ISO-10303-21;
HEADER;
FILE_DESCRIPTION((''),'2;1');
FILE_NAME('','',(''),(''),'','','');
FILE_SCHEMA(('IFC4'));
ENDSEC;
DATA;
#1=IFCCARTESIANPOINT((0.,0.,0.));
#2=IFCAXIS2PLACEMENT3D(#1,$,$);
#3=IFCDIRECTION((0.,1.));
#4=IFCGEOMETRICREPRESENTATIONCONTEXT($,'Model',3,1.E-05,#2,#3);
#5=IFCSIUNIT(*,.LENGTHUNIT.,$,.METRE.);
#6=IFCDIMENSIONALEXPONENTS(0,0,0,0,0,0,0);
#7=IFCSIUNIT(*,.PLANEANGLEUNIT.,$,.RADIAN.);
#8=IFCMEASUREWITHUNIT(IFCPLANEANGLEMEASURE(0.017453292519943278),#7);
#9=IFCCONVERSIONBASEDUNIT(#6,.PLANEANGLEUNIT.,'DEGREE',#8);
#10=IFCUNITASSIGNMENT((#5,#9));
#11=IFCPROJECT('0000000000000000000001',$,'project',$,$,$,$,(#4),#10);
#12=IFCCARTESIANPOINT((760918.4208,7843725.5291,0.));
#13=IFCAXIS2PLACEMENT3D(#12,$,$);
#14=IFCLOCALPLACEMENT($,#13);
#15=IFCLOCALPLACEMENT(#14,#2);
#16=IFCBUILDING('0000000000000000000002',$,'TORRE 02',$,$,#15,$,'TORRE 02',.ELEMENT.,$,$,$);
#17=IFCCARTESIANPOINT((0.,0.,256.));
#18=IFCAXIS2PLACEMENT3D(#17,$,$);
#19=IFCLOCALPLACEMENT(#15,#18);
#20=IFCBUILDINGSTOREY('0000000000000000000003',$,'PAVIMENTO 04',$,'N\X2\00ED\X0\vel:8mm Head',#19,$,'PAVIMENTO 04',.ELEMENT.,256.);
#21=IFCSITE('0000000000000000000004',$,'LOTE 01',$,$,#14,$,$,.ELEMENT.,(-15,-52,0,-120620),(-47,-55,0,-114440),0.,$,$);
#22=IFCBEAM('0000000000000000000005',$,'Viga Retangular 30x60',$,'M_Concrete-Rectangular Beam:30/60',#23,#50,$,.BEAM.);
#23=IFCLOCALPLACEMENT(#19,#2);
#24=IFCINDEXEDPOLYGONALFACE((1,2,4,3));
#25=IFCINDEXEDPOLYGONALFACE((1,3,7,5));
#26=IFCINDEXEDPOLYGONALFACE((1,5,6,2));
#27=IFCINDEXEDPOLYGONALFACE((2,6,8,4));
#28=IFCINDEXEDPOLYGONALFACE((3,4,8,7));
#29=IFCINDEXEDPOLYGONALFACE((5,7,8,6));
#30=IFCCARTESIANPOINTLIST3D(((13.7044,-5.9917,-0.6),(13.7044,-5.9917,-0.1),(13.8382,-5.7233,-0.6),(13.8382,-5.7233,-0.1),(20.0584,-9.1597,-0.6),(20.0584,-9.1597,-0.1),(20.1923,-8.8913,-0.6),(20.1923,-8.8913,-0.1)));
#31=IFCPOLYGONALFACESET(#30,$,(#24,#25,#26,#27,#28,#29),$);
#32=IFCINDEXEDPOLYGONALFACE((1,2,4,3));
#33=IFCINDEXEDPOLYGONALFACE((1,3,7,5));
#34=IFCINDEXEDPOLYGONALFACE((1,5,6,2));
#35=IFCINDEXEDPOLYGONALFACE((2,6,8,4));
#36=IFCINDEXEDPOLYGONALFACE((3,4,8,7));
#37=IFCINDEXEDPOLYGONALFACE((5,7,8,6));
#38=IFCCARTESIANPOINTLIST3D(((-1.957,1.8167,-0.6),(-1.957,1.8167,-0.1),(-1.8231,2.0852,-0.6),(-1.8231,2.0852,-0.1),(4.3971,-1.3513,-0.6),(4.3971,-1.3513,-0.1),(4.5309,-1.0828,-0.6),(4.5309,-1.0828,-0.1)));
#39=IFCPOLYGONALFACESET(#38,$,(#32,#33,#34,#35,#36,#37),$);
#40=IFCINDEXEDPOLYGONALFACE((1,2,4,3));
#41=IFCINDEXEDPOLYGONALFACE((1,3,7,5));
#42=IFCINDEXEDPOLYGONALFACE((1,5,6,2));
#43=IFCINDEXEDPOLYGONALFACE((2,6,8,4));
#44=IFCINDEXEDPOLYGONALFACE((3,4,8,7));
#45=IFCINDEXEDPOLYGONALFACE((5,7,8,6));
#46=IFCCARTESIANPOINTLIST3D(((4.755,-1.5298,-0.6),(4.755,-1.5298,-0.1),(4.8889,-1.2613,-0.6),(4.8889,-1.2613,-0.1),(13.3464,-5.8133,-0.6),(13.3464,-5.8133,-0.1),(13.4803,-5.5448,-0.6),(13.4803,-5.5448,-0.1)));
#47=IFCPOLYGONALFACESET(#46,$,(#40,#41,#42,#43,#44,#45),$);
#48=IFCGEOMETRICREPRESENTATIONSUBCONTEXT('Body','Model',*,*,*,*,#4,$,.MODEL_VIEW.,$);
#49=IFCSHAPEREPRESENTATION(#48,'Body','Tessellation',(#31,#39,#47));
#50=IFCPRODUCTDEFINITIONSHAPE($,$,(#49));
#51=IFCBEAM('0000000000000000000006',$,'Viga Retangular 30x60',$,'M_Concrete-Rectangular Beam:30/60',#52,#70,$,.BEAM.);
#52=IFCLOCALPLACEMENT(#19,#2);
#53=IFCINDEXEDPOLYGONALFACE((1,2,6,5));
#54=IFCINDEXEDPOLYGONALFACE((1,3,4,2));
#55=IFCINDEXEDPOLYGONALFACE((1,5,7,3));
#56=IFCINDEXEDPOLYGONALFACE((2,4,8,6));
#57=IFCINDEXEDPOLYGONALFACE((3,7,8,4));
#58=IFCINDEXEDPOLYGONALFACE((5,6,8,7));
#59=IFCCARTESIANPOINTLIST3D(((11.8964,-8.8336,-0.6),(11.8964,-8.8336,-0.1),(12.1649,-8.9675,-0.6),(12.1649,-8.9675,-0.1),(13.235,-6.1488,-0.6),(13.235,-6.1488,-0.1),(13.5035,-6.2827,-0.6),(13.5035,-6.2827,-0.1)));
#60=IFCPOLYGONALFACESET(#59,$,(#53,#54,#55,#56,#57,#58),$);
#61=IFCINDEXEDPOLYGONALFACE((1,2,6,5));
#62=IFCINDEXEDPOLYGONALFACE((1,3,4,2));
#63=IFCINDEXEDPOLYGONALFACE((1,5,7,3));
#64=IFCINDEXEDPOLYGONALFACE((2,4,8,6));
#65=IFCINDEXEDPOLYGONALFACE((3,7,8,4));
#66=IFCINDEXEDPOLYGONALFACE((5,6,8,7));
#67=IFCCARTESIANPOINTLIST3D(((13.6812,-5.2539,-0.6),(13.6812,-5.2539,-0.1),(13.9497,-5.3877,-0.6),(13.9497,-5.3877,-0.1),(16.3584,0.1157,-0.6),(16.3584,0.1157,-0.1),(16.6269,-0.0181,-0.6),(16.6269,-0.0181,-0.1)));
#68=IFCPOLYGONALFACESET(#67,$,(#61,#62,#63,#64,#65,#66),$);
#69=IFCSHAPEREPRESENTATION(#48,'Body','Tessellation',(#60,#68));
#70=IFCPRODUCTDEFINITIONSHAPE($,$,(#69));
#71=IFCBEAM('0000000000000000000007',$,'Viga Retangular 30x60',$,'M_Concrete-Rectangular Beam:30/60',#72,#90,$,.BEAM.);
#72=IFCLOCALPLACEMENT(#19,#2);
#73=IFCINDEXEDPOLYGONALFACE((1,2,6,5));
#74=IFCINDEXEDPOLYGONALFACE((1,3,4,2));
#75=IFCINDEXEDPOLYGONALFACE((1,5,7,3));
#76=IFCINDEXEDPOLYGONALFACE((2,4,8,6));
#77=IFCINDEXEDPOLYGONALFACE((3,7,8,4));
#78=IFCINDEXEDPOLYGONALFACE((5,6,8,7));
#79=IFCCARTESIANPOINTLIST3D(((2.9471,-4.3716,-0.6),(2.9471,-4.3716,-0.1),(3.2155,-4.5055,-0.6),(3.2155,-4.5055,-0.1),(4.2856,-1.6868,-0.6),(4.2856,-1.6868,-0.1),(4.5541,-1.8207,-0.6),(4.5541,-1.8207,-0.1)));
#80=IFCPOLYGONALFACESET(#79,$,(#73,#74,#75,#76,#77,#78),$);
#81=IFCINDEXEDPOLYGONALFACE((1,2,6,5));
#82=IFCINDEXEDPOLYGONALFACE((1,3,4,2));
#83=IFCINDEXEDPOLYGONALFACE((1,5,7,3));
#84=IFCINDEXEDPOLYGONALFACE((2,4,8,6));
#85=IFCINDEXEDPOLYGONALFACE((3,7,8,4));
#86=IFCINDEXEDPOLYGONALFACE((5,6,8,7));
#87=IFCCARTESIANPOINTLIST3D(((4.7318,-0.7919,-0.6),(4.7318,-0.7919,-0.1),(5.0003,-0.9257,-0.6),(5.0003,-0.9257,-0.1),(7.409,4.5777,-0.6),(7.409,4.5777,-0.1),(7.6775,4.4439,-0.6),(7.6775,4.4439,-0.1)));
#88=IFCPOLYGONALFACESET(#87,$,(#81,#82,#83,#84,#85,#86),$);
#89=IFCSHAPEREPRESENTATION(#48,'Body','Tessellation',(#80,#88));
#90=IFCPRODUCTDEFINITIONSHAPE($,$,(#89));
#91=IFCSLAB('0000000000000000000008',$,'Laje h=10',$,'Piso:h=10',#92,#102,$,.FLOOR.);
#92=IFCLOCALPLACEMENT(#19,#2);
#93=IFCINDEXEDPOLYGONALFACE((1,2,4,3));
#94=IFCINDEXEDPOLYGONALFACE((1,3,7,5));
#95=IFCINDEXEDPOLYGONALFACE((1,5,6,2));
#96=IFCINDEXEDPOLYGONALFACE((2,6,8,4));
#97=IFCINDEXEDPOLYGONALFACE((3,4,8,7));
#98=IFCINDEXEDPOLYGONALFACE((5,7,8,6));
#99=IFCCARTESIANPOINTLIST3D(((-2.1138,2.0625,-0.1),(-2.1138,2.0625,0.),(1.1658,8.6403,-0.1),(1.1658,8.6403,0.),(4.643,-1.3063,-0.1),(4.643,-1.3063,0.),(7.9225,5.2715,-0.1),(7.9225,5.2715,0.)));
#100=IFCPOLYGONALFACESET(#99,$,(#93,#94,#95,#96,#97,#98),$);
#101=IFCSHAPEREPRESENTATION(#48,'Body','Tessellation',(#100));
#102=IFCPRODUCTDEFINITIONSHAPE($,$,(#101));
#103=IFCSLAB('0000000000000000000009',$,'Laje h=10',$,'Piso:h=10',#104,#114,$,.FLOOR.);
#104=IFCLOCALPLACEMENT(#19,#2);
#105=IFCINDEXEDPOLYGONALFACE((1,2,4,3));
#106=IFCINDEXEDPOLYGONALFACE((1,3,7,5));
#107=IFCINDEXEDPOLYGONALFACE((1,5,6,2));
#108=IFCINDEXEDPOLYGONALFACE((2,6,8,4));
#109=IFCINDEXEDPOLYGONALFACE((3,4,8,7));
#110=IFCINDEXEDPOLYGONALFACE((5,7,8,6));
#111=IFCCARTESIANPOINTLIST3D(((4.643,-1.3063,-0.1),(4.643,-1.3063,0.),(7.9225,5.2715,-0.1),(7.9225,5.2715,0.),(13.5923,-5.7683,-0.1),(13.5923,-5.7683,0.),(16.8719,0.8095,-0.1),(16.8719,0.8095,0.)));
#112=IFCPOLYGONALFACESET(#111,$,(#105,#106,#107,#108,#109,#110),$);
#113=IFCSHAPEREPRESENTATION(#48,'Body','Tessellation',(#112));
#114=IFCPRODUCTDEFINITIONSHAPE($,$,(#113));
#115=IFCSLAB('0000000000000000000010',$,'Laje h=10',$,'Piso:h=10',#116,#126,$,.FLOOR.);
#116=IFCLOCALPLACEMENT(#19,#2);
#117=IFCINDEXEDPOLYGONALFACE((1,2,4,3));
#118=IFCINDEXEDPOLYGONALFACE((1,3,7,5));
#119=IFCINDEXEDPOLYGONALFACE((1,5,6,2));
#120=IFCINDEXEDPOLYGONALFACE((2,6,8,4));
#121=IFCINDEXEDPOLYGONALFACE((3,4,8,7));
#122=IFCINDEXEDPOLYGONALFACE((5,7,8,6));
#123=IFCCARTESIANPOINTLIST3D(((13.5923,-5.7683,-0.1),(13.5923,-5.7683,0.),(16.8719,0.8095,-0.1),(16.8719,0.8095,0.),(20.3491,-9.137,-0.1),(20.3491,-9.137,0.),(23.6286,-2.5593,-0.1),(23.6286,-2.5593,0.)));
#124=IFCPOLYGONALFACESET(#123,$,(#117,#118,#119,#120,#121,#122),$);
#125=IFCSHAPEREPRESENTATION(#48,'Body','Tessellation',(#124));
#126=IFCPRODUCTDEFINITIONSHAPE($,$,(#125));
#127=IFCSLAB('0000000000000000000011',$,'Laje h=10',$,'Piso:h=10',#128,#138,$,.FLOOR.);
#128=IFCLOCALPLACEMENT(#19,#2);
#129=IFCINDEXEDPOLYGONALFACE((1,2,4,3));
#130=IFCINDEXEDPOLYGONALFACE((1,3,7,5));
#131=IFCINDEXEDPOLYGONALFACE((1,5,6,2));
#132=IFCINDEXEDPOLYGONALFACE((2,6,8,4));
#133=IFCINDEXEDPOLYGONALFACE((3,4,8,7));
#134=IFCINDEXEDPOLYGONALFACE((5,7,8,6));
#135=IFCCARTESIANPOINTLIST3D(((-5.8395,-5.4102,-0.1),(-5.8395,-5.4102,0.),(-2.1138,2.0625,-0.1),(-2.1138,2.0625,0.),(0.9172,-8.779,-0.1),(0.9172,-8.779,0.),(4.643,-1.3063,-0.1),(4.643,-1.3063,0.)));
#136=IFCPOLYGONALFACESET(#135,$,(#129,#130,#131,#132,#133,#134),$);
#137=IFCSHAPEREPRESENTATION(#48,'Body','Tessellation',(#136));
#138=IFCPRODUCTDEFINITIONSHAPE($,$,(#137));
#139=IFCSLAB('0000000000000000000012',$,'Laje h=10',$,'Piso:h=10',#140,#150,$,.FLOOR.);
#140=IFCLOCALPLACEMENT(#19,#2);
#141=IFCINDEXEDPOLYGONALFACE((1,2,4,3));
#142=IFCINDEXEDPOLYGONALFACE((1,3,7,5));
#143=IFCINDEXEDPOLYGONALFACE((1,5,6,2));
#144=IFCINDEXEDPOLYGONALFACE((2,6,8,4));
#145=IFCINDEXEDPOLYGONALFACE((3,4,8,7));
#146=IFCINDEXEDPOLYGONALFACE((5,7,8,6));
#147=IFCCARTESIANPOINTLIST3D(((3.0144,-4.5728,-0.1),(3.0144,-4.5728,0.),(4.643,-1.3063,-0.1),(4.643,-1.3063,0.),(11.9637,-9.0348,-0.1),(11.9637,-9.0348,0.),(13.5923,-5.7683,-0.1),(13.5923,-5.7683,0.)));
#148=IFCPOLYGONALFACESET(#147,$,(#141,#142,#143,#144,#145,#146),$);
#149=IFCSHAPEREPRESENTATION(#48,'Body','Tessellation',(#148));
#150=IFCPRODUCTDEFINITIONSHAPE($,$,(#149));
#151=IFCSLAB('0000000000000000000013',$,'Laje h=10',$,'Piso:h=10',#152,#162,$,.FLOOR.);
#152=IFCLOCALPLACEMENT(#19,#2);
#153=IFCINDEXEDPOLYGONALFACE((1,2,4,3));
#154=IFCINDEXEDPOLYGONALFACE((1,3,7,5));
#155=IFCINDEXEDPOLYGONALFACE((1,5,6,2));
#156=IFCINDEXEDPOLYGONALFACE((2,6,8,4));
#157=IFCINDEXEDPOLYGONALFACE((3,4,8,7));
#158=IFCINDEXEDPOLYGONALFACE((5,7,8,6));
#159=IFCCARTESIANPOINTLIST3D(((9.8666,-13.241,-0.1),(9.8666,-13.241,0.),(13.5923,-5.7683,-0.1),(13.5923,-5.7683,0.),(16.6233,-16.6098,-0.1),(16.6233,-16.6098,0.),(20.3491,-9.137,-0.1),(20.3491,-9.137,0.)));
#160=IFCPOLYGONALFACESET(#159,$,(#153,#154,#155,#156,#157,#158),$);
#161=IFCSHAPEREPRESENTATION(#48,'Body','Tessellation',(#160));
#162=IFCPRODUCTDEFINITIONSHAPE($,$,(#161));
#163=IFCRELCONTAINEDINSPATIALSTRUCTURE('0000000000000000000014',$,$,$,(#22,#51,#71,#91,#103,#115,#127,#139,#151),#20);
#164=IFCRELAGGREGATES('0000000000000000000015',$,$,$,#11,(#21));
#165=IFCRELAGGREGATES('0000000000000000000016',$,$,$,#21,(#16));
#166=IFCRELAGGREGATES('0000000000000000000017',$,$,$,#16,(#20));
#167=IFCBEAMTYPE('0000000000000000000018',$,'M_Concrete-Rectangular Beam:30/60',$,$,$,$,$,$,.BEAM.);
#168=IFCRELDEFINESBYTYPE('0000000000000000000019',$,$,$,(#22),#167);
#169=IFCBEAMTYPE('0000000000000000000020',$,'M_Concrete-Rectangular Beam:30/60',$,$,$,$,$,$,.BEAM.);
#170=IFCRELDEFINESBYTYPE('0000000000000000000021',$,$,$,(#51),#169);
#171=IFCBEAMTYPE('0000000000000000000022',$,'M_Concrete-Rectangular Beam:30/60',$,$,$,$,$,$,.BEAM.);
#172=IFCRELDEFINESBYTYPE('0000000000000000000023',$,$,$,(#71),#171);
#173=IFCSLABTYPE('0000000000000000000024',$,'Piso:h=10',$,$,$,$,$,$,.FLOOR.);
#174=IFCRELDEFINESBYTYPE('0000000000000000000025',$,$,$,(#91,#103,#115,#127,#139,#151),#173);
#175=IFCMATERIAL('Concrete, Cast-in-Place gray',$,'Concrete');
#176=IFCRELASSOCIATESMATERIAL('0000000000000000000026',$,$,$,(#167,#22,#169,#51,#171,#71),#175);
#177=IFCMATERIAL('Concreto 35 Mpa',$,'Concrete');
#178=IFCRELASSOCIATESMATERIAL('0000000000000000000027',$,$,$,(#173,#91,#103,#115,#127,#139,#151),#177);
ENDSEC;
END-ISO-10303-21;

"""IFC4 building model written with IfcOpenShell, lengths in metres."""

from ifc_helpers import new_model, entity, si_unit, converted_unit, direction, frame, origin, place, context, subcontext, project, spatial, indexed_curve, outline, extrude, source, transform, mapped, material, type_object, type_shapes, element, save


model = new_model("IFC4")

# Units and contexts
model_context = context("Model", 3, precision=1e-05, world=origin(), true_north=direction((0.0, 1.0)))
body_context = subcontext(model_context, "Body", "Model", "MODEL_VIEW")
ifc_project = project(units=[si_unit("LENGTHUNIT", "METRE"), converted_unit("PLANEANGLEUNIT", "DEGREE", entity("IfcPlaneAngleMeasure", 0.017453292519943278), si_unit("PLANEANGLEUNIT", "RADIAN"), dimensions=[0, 0, 0, 0, 0, 0, 0])], contexts=[model_context])

# Site, building, storey
site_placement = place(None, frame((760918.4208, 7843725.5291, 0.0)))
site = spatial("IfcSite", under=ifc_project, at=site_placement, Name="LOTE 01", CompositionType="ELEMENT", RefLatitude=(-15, -52, 0, -120620), RefLongitude=(-47, -55, 0, -114440), RefElevation=0.0)
building_placement = place(site_placement, origin())
building = spatial("IfcBuilding", under=site, at=building_placement, Name="TORRE 02", LongName="TORRE 02", CompositionType="ELEMENT")
storey_placement = place(building_placement, frame((0.0, 0.0, 256.0)))
storey = spatial("IfcBuildingStorey", under=building, at=storey_placement, Name="PAVIMENTO 04", ObjectType="Nível:8mm Head", LongName="PAVIMENTO 04", CompositionType="ELEMENT", Elevation=256.0)

# Shared definitions
ifc_material_1 = material(Name="Concrete, Cast-in-Place gray", Category="Concrete")

# Beams
beam_type_1 = type_object("IfcBeamType", Name="M_Concrete-Rectangular Beam:30/60", PredefinedType="BEAM", material=ifc_material_1)
shared_shape_1 = source(origin(), body_context, "Body", "SweptSolid", [
    extrude(outline(indexed_curve([(-0.25, -0.15), (0.25, -0.15), (0.25, 0.15), (-0.25, 0.15), (-0.25, -0.15)], self_intersect=False)), frame((13.7713, -5.8575, 255.65), z_axis=(0.894934, -0.446198, 0.0), x_axis=(0.0, 0.0, -1.0)), (0.0, 0.0, 1.0), 7.1),
    extrude(outline(indexed_curve([(-0.25, -0.15), (0.25, -0.15), (0.25, 0.15), (-0.25, 0.15), (-0.25, -0.15)], self_intersect=False)), frame((-1.89, 1.951, 255.65), z_axis=(0.894934, -0.446198, 0.0), x_axis=(0.0, 0.0, -1.0)), (0.0, 0.0, 1.0), 7.1),
    extrude(outline(indexed_curve([(-0.25, -0.15), (0.25, -0.15), (0.25, 0.15), (-0.25, 0.15), (-0.25, -0.15)], self_intersect=False)), frame((4.822, -1.3955, 255.65), z_axis=(0.894934, -0.446198, 0.0), x_axis=(0.0, 0.0, -1.0)), (0.0, 0.0, 1.0), 9.6),
])
type_shapes(beam_type_1, [shared_shape_1])
beam_1_placement = place(storey_placement, frame((0.0, 0.0, -256.0)))
element("IfcBeam", 1, at=beam_1_placement, inside=storey, type_object=beam_type_1, material=ifc_material_1, Name="Viga Retangular 30x60", ObjectType="M_Concrete-Rectangular Beam:30/60", PredefinedType="BEAM", context=body_context, shape_type="MappedRepresentation", body=[
    mapped(shared_shape_1, transform((0.0, 0.0, 0.0), scale=1.0)),
])
beam_type_2 = type_object("IfcBeamType", Name="M_Concrete-Rectangular Beam:30/60", PredefinedType="BEAM", material=ifc_material_1)
shared_shape_2 = source(origin(), body_context, "Body", "SweptSolid", [
    extrude(outline(indexed_curve([(-0.25, -0.15), (0.25, -0.15), (0.25, 0.15), (-0.25, 0.15), (-0.25, -0.15)], self_intersect=False)), frame((12.0306, -8.9005, 255.65), z_axis=(0.446198, 0.894934, 0.0), x_axis=(0.0, 0.0, 1.0)), (0.0, 0.0, 1.0), 3.0),
    extrude(outline(indexed_curve([(-0.25, -0.15), (0.25, -0.15), (0.25, 0.15), (-0.25, 0.15), (-0.25, -0.15)], self_intersect=False)), frame((13.8154, -5.3208, 255.65), z_axis=(0.446198, 0.894934, 0.0), x_axis=(0.0, 0.0, 1.0)), (0.0, 0.0, 1.0), 6.0),
])
type_shapes(beam_type_2, [shared_shape_2])
beam_2_placement = place(storey_placement, frame((0.0, 0.0, -256.0)))
element("IfcBeam", 2, at=beam_2_placement, inside=storey, type_object=beam_type_2, material=ifc_material_1, Name="Viga Retangular 30x60", ObjectType="M_Concrete-Rectangular Beam:30/60", PredefinedType="BEAM", context=body_context, shape_type="MappedRepresentation", body=[
    mapped(shared_shape_2, transform((0.0, 0.0, 0.0), scale=1.0)),
])
beam_type_3 = type_object("IfcBeamType", Name="M_Concrete-Rectangular Beam:30/60", PredefinedType="BEAM", material=ifc_material_1)
shared_shape_3 = source(origin(), body_context, "Body", "SweptSolid", [
    extrude(outline(indexed_curve([(-0.25, -0.15), (0.25, -0.15), (0.25, 0.15), (-0.25, 0.15), (-0.25, -0.15)], self_intersect=False)), frame((3.0813, -4.4385, 255.65), z_axis=(0.446198, 0.894934, 0.0), x_axis=(0.0, 0.0, 1.0)), (0.0, 0.0, 1.0), 3.0),
    extrude(outline(indexed_curve([(-0.25, -0.15), (0.25, -0.15), (0.25, 0.15), (-0.25, 0.15), (-0.25, -0.15)], self_intersect=False)), frame((4.8661, -0.8588, 255.65), z_axis=(0.446198, 0.894934, 0.0), x_axis=(0.0, 0.0, 1.0)), (0.0, 0.0, 1.0), 6.0),
])
type_shapes(beam_type_3, [shared_shape_3])
beam_3_placement = place(storey_placement, frame((0.0, 0.0, -256.0)))
element("IfcBeam", 3, at=beam_3_placement, inside=storey, type_object=beam_type_3, material=ifc_material_1, Name="Viga Retangular 30x60", ObjectType="M_Concrete-Rectangular Beam:30/60", PredefinedType="BEAM", context=body_context, shape_type="MappedRepresentation", body=[
    mapped(shared_shape_3, transform((0.0, 0.0, 0.0), scale=1.0)),
])

# Slabs
ifc_material_2 = material(Name="Concreto 35 Mpa", Category="Concrete")
slab_type = type_object("IfcSlabType", Name="Piso:h=10", PredefinedType="FLOOR", material=ifc_material_2)
slab_1_placement = place(storey_placement, origin())
element("IfcSlab", 4, at=slab_1_placement, inside=storey, type_object=slab_type, material=ifc_material_2, Name="Laje h=10", ObjectType="Piso:h=10", PredefinedType="FLOOR", context=body_context, shape_type="SweptSolid", body=[
    extrude(outline(indexed_curve([(-3.675, -3.775), (3.675, -3.775), (3.675, 3.775), (-3.675, 3.775), (-3.675, -3.775)], self_intersect=False)), frame((2.9044, 3.667, 0.0), z_axis=(0.0, 0.0, -1.0), x_axis=(-0.446198, -0.894934, 0.0)), (0.0, 0.0, 1.0), 0.1),
])
slab_2_placement = place(storey_placement, origin())
element("IfcSlab", 5, at=slab_2_placement, inside=storey, type_object=slab_type, material=ifc_material_2, Name="Laje h=10", ObjectType="Piso:h=10", PredefinedType="FLOOR", context=body_context, shape_type="SweptSolid", body=[
    extrude(outline(indexed_curve([(-3.675, -5.0), (3.675, -5.0), (3.675, 5.0), (-3.675, 5.0), (-3.675, -5.0)], self_intersect=False)), frame((10.7574, -0.2484, 0.0), z_axis=(0.0, 0.0, -1.0), x_axis=(-0.446198, -0.894934, 0.0)), (0.0, 0.0, 1.0), 0.1),
])
slab_3_placement = place(storey_placement, origin())
element("IfcSlab", 6, at=slab_3_placement, inside=storey, type_object=slab_type, material=ifc_material_2, Name="Laje h=10", ObjectType="Piso:h=10", PredefinedType="FLOOR", context=body_context, shape_type="SweptSolid", body=[
    extrude(outline(indexed_curve([(-3.675, -3.775), (3.675, -3.775), (3.675, 3.775), (-3.675, 3.775), (-3.675, -3.775)], self_intersect=False)), frame((18.6105, -4.1638, 0.0), z_axis=(0.0, 0.0, -1.0), x_axis=(-0.446198, -0.894934, 0.0)), (0.0, 0.0, 1.0), 0.1),
])
slab_4_placement = place(storey_placement, origin())
element("IfcSlab", 7, at=slab_4_placement, inside=storey, type_object=slab_type, material=ifc_material_2, Name="Laje h=10", ObjectType="Piso:h=10", PredefinedType="FLOOR", context=body_context, shape_type="SweptSolid", body=[
    extrude(outline(indexed_curve([(-4.175, -3.775), (4.175, -3.775), (4.175, 3.775), (-4.175, 3.775), (-4.175, -3.775)], self_intersect=False)), frame((-0.5983, -3.3582, 0.0), z_axis=(0.0, 0.0, -1.0), x_axis=(-0.446198, -0.894934, 0.0)), (0.0, 0.0, 1.0), 0.1),
])
slab_5_placement = place(storey_placement, origin())
element("IfcSlab", 8, at=slab_5_placement, inside=storey, type_object=slab_type, material=ifc_material_2, Name="Laje h=10", ObjectType="Piso:h=10", PredefinedType="FLOOR", context=body_context, shape_type="SweptSolid", body=[
    extrude(outline(indexed_curve([(-1.825, -5.0), (1.825, -5.0), (1.825, 5.0), (-1.825, 5.0), (-1.825, -5.0)], self_intersect=False)), frame((8.3033, -5.1705, 0.0), z_axis=(0.0, 0.0, -1.0), x_axis=(-0.446198, -0.894934, 0.0)), (0.0, 0.0, 1.0), 0.1),
])
slab_6_placement = place(storey_placement, origin())
element("IfcSlab", 9, at=slab_6_placement, inside=storey, type_object=slab_type, material=ifc_material_2, Name="Laje h=10", ObjectType="Piso:h=10", PredefinedType="FLOOR", context=body_context, shape_type="SweptSolid", body=[
    extrude(outline(indexed_curve([(-4.175, -3.775), (4.175, -3.775), (4.175, 3.775), (-4.175, 3.775), (-4.175, -3.775)], self_intersect=False)), frame((15.1078, -11.189, 0.0), z_axis=(0.0, 0.0, -1.0), x_axis=(-0.446198, -0.894934, 0.0)), (0.0, 0.0, 1.0), 0.1),
])

save(model, "model.ifc")
